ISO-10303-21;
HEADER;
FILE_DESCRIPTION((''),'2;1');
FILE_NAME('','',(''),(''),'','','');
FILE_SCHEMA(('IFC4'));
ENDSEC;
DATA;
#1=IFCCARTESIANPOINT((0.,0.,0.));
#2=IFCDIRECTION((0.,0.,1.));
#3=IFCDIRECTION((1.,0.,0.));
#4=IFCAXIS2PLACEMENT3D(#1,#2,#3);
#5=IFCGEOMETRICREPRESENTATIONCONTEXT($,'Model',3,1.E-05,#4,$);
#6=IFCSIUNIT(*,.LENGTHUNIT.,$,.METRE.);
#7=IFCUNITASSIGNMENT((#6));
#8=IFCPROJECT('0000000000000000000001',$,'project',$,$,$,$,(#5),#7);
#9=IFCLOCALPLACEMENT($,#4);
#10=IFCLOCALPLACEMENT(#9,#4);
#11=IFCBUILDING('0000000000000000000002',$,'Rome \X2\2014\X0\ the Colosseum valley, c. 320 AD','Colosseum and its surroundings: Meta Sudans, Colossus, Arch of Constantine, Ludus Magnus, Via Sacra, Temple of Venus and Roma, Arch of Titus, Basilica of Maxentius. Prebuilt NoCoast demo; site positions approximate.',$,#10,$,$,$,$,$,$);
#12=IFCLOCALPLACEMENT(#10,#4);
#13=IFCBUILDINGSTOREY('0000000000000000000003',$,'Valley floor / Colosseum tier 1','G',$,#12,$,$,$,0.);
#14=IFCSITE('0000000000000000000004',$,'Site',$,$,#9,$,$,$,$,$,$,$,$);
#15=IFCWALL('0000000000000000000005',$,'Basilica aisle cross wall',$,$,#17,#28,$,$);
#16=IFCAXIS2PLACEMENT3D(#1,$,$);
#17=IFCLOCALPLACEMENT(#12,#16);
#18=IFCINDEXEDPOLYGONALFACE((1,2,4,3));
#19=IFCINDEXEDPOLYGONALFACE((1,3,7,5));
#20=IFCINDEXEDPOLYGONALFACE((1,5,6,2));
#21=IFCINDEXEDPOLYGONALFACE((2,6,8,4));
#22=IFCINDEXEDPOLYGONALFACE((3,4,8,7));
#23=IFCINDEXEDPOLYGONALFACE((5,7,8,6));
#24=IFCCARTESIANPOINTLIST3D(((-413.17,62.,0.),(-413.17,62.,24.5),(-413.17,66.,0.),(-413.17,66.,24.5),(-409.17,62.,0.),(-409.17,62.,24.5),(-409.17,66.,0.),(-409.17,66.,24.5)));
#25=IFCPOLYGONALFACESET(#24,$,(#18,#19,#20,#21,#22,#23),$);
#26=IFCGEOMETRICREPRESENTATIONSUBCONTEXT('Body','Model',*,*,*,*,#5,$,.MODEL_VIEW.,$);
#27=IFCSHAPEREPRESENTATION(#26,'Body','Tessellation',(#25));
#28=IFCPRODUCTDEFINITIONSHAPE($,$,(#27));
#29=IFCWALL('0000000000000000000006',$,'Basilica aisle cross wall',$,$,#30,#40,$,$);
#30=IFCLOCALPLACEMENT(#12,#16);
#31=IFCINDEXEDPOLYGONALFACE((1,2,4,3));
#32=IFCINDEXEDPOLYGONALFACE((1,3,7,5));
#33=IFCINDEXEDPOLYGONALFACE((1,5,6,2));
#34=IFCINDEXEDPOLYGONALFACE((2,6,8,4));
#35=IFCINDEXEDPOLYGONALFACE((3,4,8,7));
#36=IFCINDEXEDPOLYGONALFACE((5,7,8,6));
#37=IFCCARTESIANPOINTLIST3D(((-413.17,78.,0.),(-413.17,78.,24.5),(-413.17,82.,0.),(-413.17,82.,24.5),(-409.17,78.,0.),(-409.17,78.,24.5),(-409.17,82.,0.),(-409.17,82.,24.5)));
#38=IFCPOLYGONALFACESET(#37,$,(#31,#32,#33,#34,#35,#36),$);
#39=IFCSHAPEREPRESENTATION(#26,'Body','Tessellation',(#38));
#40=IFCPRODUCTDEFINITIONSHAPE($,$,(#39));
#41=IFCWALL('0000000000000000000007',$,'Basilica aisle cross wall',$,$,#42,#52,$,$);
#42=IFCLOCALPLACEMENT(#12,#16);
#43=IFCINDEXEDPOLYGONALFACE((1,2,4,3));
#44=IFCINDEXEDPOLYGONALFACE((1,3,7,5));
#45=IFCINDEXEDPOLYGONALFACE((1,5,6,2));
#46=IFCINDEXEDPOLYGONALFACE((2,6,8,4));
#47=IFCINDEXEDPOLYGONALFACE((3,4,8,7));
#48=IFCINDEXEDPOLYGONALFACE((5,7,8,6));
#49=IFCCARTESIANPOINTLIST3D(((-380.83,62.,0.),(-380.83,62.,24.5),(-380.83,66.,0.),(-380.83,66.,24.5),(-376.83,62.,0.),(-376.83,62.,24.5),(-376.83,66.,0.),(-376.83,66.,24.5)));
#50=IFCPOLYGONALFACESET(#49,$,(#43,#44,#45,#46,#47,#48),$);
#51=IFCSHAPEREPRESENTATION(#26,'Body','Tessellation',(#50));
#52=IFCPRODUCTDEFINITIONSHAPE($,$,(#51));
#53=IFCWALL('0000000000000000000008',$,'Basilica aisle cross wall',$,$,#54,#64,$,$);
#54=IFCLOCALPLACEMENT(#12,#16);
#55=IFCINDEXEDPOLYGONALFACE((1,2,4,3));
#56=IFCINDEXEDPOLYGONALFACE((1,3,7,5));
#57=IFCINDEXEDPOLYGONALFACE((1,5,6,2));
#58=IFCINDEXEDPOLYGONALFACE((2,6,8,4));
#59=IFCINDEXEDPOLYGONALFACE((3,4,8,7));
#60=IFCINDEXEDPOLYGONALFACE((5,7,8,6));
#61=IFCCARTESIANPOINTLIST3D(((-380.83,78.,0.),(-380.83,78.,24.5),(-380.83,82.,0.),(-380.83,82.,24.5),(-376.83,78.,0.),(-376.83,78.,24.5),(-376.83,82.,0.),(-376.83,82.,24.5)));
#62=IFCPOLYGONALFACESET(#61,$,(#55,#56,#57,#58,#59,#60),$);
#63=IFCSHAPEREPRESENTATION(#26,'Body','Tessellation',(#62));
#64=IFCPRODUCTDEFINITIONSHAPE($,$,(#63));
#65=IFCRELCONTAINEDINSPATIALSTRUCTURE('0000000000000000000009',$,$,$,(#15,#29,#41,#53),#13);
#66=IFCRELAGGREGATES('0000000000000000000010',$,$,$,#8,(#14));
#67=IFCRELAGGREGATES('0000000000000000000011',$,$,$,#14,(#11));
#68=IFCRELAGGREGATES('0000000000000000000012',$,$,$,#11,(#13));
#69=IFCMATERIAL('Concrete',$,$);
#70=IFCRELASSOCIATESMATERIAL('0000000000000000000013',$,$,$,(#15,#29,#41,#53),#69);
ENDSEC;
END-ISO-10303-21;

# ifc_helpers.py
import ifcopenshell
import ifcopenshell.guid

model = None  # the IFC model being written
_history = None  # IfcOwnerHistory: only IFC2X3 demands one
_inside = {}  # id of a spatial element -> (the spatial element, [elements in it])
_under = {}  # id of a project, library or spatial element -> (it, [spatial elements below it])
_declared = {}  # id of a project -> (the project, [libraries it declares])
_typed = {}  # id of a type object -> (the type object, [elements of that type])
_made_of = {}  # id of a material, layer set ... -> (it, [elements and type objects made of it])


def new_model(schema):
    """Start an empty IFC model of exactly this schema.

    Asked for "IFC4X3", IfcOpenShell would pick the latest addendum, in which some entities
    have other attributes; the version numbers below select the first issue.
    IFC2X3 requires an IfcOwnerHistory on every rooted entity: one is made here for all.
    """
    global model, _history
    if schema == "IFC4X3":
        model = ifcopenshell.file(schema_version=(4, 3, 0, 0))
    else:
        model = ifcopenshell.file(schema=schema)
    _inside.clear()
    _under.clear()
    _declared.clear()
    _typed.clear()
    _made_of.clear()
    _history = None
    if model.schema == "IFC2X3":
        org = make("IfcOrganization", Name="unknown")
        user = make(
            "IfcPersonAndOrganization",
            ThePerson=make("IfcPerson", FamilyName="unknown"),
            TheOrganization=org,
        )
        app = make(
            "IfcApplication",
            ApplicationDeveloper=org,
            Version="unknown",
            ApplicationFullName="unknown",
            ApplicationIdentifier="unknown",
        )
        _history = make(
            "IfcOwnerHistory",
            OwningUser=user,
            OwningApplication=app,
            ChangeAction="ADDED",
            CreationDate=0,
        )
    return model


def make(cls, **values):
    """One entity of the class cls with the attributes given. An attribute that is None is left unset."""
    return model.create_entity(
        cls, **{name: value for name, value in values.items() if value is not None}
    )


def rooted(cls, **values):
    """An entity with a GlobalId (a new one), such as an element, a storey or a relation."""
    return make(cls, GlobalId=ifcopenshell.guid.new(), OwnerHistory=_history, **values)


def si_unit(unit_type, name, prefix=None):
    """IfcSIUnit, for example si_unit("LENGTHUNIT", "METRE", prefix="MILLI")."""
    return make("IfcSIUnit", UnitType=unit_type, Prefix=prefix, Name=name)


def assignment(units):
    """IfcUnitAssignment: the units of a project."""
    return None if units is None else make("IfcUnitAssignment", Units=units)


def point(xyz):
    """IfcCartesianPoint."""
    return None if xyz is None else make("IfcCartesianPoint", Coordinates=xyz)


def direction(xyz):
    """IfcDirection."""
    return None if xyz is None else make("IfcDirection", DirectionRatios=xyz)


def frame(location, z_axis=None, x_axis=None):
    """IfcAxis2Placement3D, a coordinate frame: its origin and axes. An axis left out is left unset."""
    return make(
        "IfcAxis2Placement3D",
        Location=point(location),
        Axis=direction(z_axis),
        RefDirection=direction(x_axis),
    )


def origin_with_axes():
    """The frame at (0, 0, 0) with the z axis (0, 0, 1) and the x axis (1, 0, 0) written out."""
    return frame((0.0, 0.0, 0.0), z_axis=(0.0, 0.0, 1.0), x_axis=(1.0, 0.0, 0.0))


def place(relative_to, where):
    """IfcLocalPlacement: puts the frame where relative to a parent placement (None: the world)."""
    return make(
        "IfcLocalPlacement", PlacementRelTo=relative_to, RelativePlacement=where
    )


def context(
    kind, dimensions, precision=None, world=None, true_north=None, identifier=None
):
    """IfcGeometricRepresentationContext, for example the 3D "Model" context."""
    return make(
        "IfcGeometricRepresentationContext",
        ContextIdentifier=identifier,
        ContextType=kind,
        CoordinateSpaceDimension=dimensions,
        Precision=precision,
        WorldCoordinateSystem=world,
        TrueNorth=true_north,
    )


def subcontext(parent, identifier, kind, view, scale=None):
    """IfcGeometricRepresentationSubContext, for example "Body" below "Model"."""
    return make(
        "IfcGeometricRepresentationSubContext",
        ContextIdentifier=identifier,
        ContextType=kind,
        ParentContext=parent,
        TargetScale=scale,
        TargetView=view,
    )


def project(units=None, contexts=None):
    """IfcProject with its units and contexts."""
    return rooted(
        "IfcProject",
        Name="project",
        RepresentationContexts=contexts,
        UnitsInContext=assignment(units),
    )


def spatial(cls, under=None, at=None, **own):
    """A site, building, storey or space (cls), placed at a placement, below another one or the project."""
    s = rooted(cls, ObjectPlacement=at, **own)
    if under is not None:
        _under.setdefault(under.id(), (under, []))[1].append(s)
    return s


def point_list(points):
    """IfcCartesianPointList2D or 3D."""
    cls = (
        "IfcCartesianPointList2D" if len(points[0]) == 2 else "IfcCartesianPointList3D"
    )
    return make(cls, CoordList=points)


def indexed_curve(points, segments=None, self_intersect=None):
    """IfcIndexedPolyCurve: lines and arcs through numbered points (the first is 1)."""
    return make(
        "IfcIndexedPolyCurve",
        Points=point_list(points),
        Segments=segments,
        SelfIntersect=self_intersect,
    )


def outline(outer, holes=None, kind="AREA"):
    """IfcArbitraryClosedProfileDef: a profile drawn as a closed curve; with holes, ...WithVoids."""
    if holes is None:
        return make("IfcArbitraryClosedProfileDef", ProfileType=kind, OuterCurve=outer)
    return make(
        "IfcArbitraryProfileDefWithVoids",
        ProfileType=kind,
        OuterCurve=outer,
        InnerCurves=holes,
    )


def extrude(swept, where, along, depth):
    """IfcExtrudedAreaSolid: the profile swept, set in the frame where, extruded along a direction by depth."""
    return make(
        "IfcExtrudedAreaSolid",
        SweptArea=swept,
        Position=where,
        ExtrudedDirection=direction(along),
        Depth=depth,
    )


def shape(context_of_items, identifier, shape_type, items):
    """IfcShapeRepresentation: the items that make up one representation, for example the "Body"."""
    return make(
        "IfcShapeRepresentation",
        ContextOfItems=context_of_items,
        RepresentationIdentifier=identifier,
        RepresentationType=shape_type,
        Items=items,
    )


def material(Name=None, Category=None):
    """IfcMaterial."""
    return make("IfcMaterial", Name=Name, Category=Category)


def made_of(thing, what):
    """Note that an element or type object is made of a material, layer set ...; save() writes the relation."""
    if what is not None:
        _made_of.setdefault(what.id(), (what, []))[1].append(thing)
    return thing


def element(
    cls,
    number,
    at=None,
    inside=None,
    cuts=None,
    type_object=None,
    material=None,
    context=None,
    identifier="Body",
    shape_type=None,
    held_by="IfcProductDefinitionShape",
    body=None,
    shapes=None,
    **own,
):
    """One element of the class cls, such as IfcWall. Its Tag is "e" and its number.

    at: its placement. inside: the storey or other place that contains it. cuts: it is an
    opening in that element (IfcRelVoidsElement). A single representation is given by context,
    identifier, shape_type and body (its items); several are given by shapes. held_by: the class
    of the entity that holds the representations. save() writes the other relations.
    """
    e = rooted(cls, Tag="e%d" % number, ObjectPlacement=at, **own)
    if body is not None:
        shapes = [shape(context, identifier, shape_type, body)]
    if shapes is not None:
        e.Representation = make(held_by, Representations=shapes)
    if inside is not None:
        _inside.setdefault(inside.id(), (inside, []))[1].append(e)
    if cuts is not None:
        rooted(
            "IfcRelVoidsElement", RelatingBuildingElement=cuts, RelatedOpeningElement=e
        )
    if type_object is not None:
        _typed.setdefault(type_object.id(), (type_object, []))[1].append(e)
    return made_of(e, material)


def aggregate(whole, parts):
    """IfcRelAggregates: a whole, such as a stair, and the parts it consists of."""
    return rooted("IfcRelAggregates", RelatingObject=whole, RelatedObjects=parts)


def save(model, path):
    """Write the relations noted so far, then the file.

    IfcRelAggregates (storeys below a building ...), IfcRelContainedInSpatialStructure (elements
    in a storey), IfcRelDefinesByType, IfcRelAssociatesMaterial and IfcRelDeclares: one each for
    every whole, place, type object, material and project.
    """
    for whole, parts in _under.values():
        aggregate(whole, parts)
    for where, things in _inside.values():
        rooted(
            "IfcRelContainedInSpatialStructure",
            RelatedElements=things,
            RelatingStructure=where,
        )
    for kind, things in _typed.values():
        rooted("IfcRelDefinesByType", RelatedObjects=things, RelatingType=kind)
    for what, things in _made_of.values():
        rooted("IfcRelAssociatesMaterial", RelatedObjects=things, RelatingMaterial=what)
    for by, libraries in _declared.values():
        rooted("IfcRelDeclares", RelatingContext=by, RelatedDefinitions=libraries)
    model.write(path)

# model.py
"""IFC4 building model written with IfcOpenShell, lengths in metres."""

from ifc_helpers import new_model, si_unit, frame, origin_with_axes, place, context, subcontext, project, spatial, indexed_curve, outline, extrude, material, element, save


model = new_model("IFC4")

# Units and contexts
model_context = context("Model", 3, precision=1e-05, world=origin_with_axes())
body_context = subcontext(model_context, "Body", "Model", "MODEL_VIEW")
ifc_project = project(units=[si_unit("LENGTHUNIT", "METRE")], contexts=[model_context])

# Site, building, storey
site_placement = place(None, origin_with_axes())
site = spatial("IfcSite", under=ifc_project, at=site_placement, Name="Site")
building_placement = place(site_placement, origin_with_axes())
building = spatial("IfcBuilding", under=site, at=building_placement, Name="Rome — the Colosseum valley, c. 320 AD", Description="Colosseum and its surroundings: Meta Sudans, Colossus, Arch of Constantine, Ludus Magnus, Via Sacra, Temple of Venus and Roma, Arch of Titus, Basilica of Maxentius. Prebuilt NoCoast demo; site positions approximate.")
storey_placement = place(building_placement, origin_with_axes())
storey = spatial("IfcBuildingStorey", under=building, at=storey_placement, Name="Valley floor / Colosseum tier 1", Description="G", Elevation=0.0)

# Shared definitions
ifc_material_1 = material(Name="Concrete")

# Walls
for number, where, z_axis, x_axis, name in (
    (1, (-411.17, 62.0, 0.0), (0.0, 0.0, 1.0), (0.0, 1.0, 0.0), "Basilica aisle cross wall"),
    (2, (-411.17, 78.0, 0.0), (0.0, 0.0, 1.0), (0.0, 1.0, 0.0), "Basilica aisle cross wall"),
    (3, (-378.83, 62.0, 0.0), (0.0, 0.0, 1.0), (0.0, 1.0, 0.0), "Basilica aisle cross wall"),
    (4, (-378.83, 78.0, 0.0), (0.0, 0.0, 1.0), (0.0, 1.0, 0.0), "Basilica aisle cross wall"),
):
    element("IfcWall", number, at=place(storey_placement, frame(where, z_axis=z_axis, x_axis=x_axis)), inside=storey, material=ifc_material_1, Name=name, context=body_context, shape_type="SweptSolid", body=[
        extrude(outline(indexed_curve([(0.0, 0.0), (0.0, 4.0), (4.0, 4.0), (4.0, 0.0), (0.0, 0.0)], self_intersect=False)), frame((0.0, -2.0, 0.0), z_axis=(0.0, 0.0, 1.0), x_axis=(1.0, 0.0, 0.0)), (0.0, 0.0, 1.0), 24.5),
    ])

save(model, "model.ifc")
